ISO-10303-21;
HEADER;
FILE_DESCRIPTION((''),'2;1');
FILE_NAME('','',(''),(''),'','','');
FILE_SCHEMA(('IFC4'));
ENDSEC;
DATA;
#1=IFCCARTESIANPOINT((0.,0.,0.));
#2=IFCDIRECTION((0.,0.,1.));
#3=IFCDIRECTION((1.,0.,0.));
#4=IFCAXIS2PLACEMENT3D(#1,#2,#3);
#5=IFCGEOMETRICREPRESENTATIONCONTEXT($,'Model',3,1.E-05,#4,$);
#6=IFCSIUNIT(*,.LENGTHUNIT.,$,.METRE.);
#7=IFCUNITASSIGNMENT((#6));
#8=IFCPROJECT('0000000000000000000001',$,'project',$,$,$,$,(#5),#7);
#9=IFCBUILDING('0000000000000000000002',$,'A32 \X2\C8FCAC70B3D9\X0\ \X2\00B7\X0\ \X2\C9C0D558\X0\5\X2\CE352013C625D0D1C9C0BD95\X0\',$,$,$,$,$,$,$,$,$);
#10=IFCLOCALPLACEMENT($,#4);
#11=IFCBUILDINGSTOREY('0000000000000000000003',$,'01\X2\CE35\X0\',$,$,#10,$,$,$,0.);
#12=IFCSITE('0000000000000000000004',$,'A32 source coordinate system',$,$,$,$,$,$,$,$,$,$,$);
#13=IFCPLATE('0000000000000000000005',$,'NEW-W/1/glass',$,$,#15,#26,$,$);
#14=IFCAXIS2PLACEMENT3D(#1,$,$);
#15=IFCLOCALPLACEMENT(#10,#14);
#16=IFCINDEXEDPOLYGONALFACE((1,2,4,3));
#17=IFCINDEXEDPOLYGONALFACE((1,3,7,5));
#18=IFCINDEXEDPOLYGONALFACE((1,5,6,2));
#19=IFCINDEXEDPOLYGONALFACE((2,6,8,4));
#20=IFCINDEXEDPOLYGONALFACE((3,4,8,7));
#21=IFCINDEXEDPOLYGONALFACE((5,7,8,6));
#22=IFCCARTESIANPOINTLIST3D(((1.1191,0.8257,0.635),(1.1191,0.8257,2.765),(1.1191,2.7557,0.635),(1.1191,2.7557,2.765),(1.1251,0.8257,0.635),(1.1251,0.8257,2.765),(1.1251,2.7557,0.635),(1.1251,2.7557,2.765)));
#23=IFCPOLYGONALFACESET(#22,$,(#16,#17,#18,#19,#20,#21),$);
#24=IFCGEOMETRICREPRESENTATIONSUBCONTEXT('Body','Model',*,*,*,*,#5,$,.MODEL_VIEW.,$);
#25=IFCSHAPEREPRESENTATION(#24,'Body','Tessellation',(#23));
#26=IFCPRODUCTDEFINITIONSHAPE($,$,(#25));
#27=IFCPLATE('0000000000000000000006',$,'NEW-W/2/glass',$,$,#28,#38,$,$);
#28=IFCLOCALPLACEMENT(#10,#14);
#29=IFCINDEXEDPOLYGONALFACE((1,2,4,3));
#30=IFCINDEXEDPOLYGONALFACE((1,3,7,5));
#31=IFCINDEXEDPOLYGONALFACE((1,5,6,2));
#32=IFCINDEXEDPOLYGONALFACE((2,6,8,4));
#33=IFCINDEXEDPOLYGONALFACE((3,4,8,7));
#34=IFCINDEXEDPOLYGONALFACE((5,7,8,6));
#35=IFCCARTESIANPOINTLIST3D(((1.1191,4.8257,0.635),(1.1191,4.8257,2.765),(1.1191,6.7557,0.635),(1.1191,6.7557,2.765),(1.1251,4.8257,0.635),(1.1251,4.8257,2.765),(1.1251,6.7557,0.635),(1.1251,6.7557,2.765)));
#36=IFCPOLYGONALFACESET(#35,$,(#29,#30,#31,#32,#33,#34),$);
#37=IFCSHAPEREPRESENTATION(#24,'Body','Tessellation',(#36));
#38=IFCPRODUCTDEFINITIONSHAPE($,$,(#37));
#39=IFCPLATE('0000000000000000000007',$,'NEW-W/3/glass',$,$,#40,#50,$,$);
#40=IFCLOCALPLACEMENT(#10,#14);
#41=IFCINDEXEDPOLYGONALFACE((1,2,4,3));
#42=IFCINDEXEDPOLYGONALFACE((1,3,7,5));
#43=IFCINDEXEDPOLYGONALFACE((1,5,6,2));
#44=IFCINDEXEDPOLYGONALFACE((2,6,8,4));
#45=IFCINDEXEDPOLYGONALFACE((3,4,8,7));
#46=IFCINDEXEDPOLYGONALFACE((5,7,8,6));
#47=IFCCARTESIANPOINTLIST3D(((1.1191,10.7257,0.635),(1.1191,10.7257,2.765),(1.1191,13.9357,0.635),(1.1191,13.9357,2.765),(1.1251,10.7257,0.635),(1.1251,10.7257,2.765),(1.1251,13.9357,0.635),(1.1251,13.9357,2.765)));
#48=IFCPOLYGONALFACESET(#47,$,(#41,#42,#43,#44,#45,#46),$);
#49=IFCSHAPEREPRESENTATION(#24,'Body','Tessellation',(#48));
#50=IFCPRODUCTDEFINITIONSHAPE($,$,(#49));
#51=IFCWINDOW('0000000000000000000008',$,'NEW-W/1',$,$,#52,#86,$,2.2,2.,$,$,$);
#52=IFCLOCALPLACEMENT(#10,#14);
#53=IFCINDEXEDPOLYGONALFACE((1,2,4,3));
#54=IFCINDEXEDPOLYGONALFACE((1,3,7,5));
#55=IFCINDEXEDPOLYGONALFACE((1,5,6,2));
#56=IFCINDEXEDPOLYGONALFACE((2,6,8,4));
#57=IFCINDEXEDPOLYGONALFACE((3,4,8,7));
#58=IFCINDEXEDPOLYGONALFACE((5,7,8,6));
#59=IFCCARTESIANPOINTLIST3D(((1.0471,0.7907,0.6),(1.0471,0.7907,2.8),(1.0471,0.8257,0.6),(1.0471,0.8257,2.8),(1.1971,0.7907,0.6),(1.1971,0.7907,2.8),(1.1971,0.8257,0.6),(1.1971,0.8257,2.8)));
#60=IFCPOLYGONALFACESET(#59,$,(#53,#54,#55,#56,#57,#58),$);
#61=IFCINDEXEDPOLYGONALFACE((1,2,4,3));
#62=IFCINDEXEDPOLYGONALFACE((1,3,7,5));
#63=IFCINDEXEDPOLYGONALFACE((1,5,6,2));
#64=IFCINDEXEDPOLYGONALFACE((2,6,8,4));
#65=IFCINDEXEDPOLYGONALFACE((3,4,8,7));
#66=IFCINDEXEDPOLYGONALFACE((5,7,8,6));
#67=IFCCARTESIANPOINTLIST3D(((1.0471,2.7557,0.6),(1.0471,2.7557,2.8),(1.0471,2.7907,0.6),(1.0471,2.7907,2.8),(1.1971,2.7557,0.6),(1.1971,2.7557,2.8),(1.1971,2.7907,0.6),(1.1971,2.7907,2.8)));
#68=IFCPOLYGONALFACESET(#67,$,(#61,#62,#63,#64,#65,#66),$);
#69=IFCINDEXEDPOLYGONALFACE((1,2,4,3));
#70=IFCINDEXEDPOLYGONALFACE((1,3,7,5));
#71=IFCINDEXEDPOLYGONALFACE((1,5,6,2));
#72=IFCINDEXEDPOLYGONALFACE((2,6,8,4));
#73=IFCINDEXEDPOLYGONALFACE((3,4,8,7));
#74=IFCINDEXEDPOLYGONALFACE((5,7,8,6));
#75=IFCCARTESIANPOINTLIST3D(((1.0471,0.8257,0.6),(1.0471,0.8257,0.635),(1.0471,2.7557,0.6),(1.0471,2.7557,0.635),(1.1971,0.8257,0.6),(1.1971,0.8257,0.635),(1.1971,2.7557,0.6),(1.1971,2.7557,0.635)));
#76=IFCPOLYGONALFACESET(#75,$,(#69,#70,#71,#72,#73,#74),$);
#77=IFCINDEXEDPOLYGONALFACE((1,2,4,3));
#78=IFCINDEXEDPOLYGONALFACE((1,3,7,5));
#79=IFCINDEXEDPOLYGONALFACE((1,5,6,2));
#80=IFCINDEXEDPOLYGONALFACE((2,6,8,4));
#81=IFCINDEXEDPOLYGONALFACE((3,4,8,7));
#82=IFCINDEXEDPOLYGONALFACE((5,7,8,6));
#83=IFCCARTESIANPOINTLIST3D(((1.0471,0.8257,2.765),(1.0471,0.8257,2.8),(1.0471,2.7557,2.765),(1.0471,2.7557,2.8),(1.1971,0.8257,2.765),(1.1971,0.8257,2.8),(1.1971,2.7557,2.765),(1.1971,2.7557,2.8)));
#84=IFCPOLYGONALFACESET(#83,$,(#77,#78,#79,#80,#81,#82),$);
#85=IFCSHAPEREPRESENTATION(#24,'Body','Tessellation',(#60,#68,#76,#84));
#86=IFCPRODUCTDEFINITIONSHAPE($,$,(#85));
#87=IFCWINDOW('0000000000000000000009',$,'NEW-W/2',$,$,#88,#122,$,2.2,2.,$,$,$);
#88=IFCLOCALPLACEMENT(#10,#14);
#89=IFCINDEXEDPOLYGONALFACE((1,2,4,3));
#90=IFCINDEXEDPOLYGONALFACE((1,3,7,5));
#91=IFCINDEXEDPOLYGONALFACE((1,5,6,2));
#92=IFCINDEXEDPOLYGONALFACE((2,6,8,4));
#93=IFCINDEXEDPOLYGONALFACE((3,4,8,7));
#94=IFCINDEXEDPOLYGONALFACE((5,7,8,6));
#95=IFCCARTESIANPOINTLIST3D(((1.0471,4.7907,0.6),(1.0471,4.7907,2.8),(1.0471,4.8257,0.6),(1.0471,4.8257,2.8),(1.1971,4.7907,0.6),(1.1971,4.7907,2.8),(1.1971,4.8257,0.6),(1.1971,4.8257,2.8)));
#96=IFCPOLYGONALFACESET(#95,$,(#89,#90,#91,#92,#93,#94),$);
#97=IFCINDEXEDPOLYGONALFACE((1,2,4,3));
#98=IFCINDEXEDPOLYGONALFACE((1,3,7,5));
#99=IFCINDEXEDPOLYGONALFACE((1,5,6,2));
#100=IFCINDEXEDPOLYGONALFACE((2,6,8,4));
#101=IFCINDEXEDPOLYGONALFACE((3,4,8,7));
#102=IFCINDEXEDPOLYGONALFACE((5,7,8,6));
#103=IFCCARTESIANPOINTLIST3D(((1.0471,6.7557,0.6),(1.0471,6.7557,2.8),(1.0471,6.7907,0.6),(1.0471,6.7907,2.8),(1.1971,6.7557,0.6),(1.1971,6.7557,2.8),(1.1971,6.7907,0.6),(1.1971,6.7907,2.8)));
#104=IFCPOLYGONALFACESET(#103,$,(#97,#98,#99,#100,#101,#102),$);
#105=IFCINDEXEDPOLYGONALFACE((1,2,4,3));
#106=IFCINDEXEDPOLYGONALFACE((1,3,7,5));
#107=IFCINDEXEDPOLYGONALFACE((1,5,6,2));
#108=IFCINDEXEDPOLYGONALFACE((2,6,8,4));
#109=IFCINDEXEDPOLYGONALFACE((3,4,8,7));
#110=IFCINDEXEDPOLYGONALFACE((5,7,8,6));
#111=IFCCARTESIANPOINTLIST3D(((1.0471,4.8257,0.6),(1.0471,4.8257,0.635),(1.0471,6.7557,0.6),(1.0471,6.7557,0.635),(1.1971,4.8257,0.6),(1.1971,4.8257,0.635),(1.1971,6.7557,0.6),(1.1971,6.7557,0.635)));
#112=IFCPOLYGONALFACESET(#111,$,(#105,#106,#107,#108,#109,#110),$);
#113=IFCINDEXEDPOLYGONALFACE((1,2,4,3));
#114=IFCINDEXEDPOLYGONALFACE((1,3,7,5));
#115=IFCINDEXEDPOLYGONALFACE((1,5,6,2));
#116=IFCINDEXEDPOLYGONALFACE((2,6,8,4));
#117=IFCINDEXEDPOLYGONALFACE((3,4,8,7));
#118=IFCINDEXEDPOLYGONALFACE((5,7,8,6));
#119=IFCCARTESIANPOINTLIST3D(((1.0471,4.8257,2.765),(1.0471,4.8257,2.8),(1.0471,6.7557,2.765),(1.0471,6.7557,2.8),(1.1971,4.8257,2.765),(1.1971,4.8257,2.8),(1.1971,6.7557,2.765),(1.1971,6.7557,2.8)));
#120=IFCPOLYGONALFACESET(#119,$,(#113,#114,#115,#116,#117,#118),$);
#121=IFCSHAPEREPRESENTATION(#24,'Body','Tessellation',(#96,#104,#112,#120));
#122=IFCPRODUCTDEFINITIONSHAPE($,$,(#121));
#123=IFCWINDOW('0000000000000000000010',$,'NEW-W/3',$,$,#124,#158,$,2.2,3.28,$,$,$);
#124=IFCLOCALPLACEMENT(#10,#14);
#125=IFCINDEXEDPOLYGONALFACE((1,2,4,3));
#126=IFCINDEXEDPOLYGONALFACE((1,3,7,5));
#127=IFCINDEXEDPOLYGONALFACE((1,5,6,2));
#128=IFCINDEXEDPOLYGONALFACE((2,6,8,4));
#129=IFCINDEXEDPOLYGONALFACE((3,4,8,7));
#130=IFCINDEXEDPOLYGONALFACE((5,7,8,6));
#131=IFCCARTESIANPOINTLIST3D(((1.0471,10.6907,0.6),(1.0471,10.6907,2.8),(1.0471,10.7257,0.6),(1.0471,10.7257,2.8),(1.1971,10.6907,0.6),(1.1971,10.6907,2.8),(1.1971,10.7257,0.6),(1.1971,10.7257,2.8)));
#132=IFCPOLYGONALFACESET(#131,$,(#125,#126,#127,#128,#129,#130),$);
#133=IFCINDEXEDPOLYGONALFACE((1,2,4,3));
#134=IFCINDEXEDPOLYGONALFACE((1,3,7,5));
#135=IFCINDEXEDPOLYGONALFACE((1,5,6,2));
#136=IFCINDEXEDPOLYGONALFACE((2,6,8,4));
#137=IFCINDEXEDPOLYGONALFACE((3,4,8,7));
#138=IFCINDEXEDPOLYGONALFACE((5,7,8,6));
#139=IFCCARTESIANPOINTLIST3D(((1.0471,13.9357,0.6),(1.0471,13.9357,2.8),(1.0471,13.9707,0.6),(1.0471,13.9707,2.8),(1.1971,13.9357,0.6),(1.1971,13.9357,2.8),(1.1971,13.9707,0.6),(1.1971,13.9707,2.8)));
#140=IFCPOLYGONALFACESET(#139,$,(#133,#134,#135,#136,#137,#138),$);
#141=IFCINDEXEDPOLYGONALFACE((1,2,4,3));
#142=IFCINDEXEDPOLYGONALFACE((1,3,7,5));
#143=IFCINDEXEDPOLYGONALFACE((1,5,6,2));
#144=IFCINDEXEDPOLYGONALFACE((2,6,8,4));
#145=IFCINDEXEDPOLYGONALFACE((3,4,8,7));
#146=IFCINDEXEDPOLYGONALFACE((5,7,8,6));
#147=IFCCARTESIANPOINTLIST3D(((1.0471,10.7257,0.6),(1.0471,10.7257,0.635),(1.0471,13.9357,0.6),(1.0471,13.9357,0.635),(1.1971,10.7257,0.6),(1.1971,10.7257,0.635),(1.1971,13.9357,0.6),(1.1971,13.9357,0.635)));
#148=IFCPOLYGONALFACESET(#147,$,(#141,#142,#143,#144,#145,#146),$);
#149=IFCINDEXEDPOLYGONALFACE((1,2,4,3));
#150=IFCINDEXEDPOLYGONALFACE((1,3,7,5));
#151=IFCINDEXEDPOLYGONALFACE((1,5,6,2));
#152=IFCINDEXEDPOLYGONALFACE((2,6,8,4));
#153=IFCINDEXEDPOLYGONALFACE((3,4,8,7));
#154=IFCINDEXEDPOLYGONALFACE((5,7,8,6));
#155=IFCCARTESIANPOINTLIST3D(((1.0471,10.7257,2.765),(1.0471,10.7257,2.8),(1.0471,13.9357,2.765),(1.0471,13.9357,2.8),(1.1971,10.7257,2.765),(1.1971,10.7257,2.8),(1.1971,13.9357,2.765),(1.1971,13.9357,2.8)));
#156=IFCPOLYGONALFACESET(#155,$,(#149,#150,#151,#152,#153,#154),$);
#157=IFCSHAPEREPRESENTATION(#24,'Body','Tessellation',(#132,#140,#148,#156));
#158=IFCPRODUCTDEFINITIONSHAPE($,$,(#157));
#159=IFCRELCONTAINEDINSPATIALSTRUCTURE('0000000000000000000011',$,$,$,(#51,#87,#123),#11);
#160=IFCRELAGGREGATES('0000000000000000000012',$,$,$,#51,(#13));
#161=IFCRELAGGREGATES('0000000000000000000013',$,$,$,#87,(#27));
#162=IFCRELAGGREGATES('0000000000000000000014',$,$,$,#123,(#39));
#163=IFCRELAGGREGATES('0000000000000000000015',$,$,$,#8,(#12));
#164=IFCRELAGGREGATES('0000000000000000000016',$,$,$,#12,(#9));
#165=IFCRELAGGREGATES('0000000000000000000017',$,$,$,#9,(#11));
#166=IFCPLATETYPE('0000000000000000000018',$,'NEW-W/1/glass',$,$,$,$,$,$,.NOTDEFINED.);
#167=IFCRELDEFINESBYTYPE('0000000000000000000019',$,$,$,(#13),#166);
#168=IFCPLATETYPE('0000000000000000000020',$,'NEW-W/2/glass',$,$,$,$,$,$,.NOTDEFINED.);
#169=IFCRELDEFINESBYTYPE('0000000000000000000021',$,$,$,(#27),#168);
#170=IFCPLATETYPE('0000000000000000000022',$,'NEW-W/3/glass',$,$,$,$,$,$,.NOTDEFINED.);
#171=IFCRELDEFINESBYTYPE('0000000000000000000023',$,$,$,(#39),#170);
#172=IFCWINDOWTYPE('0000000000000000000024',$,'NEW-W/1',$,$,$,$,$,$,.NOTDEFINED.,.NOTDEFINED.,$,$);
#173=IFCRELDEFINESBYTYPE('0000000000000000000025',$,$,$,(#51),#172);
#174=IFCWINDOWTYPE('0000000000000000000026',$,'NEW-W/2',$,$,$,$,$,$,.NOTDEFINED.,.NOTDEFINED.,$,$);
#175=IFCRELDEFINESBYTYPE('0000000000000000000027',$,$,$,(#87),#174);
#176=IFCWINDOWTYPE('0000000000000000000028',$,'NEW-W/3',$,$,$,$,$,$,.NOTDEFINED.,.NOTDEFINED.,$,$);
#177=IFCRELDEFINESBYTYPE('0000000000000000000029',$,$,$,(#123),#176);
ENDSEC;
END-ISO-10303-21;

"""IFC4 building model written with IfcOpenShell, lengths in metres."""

from ifc_helpers import new_model, si_unit, frame, origin, origin_with_axes, place, context, subcontext, project, spatial, polyline, outline, extrude, source, transform, mapped, type_object, type_shapes, element, aggregate, save


model = new_model("IFC4")

# Units and contexts
model_context = context("Model", 3, precision=1e-05, world=origin_with_axes())
body_context = subcontext(model_context, "Body", "Model", "MODEL_VIEW")
ifc_project = project(units=[si_unit("LENGTHUNIT", "METRE")], contexts=[model_context])

# Plates
plate_type_1 = type_object("IfcPlateType", Name="NEW-W/1/glass", PredefinedType="NOTDEFINED")
shared_shape_1 = source(origin(), body_context, "Body", "SweptSolid", [
    extrude(outline(polyline([(1.1251, 0.8257), (1.1191, 0.8257), (1.1191, 2.7557), (1.1251, 2.7557), (1.1251, 0.8257)])), frame((0.0, 0.0, 0.635)), (0.0, 0.0, 1.0), 2.13),
])
type_shapes(plate_type_1, [shared_shape_1])
storey_placement = place(None, origin_with_axes())
window_1_placement = place(storey_placement, origin_with_axes())
plate_1_placement = place(window_1_placement, origin_with_axes())
plate_1 = element("IfcPlate", 1, at=plate_1_placement, type_object=plate_type_1, Name="NEW-W/1/glass", context=body_context, shape_type="MappedRepresentation", body=[
    mapped(shared_shape_1, transform((0.0, 0.0, 0.0), scale=1.0)),
])
plate_type_2 = type_object("IfcPlateType", Name="NEW-W/2/glass", PredefinedType="NOTDEFINED")
shared_shape_2 = source(origin(), body_context, "Body", "SweptSolid", [
    extrude(outline(polyline([(1.1251, 4.8257), (1.1191, 4.8257), (1.1191, 6.7557), (1.1251, 6.7557), (1.1251, 4.8257)])), frame((0.0, 0.0, 0.635)), (0.0, 0.0, 1.0), 2.13),
])
type_shapes(plate_type_2, [shared_shape_2])
window_2_placement = place(storey_placement, origin_with_axes())
plate_2_placement = place(window_2_placement, origin_with_axes())
plate_2 = element("IfcPlate", 2, at=plate_2_placement, type_object=plate_type_2, Name="NEW-W/2/glass", context=body_context, shape_type="MappedRepresentation", body=[
    mapped(shared_shape_2, transform((0.0, 0.0, 0.0), scale=1.0)),
])
plate_type_3 = type_object("IfcPlateType", Name="NEW-W/3/glass", PredefinedType="NOTDEFINED")
shared_shape_3 = source(origin(), body_context, "Body", "SweptSolid", [
    extrude(outline(polyline([(1.1251, 10.7257), (1.1191, 10.7257), (1.1191, 13.9357), (1.1251, 13.9357), (1.1251, 10.7257)])), frame((0.0, 0.0, 0.635)), (0.0, 0.0, 1.0), 2.13),
])
type_shapes(plate_type_3, [shared_shape_3])
window_3_placement = place(storey_placement, origin_with_axes())
plate_3_placement = place(window_3_placement, origin_with_axes())
plate_3 = element("IfcPlate", 3, at=plate_3_placement, type_object=plate_type_3, Name="NEW-W/3/glass", context=body_context, shape_type="MappedRepresentation", body=[
    mapped(shared_shape_3, transform((0.0, 0.0, 0.0), scale=1.0)),
])

# Site, building, storey
site = spatial("IfcSite", under=ifc_project, Name="A32 source coordinate system")
building = spatial("IfcBuilding", under=site, Name="A32 주거동 · 지하5층–옥탑지붕")
storey = spatial("IfcBuildingStorey", under=building, at=storey_placement, Name="01층", Elevation=0.0)

# Windows
window_type_1 = type_object("IfcWindowType", Name="NEW-W/1", PartitioningType="NOTDEFINED", PredefinedType="NOTDEFINED")
shared_shape_4 = source(origin(), body_context, "Body", "SweptSolid", [
    extrude(outline(polyline([(1.0471, 0.7907), (1.0471, 0.8257), (1.1971, 0.8257), (1.1971, 0.7907), (1.0471, 0.7907)])), frame((0.0, 0.0, 0.6)), (0.0, 0.0, 1.0), 2.2),
    extrude(outline(polyline([(1.0471, 2.7557), (1.0471, 2.7907), (1.1971, 2.7907), (1.1971, 2.7557), (1.0471, 2.7557)])), frame((0.0, 0.0, 0.6)), (0.0, 0.0, 1.0), 2.2),
    extrude(outline(polyline([(1.1971, 0.8257), (1.1971, 2.7557), (1.0471, 2.7557), (1.0471, 0.8257), (1.1971, 0.8257)])), frame((0.0, 0.0, 0.6)), (0.0, 0.0, 1.0), 0.035),
    extrude(outline(polyline([(1.1971, 0.8257), (1.1971, 2.7557), (1.0471, 2.7557), (1.0471, 0.8257), (1.1971, 0.8257)])), frame((0.0, 0.0, 2.765)), (0.0, 0.0, 1.0), 0.035),
])
type_shapes(window_type_1, [shared_shape_4])
window_1 = element("IfcWindow", 4, at=window_1_placement, inside=storey, type_object=window_type_1, Name="NEW-W/1", OverallHeight=2.2, OverallWidth=2.0, context=body_context, shape_type="MappedRepresentation", body=[
    mapped(shared_shape_4, transform((0.0, 0.0, 0.0), scale=1.0)),
])
aggregate(window_1, [plate_1])
window_type_2 = type_object("IfcWindowType", Name="NEW-W/2", PartitioningType="NOTDEFINED", PredefinedType="NOTDEFINED")
shared_shape_5 = source(origin(), body_context, "Body", "SweptSolid", [
    extrude(outline(polyline([(1.0471, 4.7907), (1.0471, 4.8257), (1.1971, 4.8257), (1.1971, 4.7907), (1.0471, 4.7907)])), frame((0.0, 0.0, 0.6)), (0.0, 0.0, 1.0), 2.2),
    extrude(outline(polyline([(1.0471, 6.7557), (1.0471, 6.7907), (1.1971, 6.7907), (1.1971, 6.7557), (1.0471, 6.7557)])), frame((0.0, 0.0, 0.6)), (0.0, 0.0, 1.0), 2.2),
    extrude(outline(polyline([(1.1971, 4.8257), (1.1971, 6.7557), (1.0471, 6.7557), (1.0471, 4.8257), (1.1971, 4.8257)])), frame((0.0, 0.0, 0.6)), (0.0, 0.0, 1.0), 0.035),
    extrude(outline(polyline([(1.1971, 4.8257), (1.1971, 6.7557), (1.0471, 6.7557), (1.0471, 4.8257), (1.1971, 4.8257)])), frame((0.0, 0.0, 2.765)), (0.0, 0.0, 1.0), 0.035),
])
type_shapes(window_type_2, [shared_shape_5])
window_2 = element("IfcWindow", 5, at=window_2_placement, inside=storey, type_object=window_type_2, Name="NEW-W/2", OverallHeight=2.2, OverallWidth=2.0, context=body_context, shape_type="MappedRepresentation", body=[
    mapped(shared_shape_5, transform((0.0, 0.0, 0.0), scale=1.0)),
])
aggregate(window_2, [plate_2])
window_type_3 = type_object("IfcWindowType", Name="NEW-W/3", PartitioningType="NOTDEFINED", PredefinedType="NOTDEFINED")
shared_shape_6 = source(origin(), body_context, "Body", "SweptSolid", [
    extrude(outline(polyline([(1.0471, 10.6907), (1.0471, 10.7257), (1.1971, 10.7257), (1.1971, 10.6907), (1.0471, 10.6907)])), frame((0.0, 0.0, 0.6)), (0.0, 0.0, 1.0), 2.2),
    extrude(outline(polyline([(1.0471, 13.9357), (1.0471, 13.9707), (1.1971, 13.9707), (1.1971, 13.9357), (1.0471, 13.9357)])), frame((0.0, 0.0, 0.6)), (0.0, 0.0, 1.0), 2.2),
    extrude(outline(polyline([(1.1971, 10.7257), (1.1971, 13.9357), (1.0471, 13.9357), (1.0471, 10.7257), (1.1971, 10.7257)])), frame((0.0, 0.0, 0.6)), (0.0, 0.0, 1.0), 0.035),
    extrude(outline(polyline([(1.1971, 10.7257), (1.1971, 13.9357), (1.0471, 13.9357), (1.0471, 10.7257), (1.1971, 10.7257)])), frame((0.0, 0.0, 2.765)), (0.0, 0.0, 1.0), 0.035),
])
type_shapes(window_type_3, [shared_shape_6])
window_3 = element("IfcWindow", 6, at=window_3_placement, inside=storey, type_object=window_type_3, Name="NEW-W/3", OverallHeight=2.2, OverallWidth=3.28, context=body_context, shape_type="MappedRepresentation", body=[
    mapped(shared_shape_6, transform((0.0, 0.0, 0.0), scale=1.0)),
])
aggregate(window_3, [plate_3])

save(model, "model.ifc")
